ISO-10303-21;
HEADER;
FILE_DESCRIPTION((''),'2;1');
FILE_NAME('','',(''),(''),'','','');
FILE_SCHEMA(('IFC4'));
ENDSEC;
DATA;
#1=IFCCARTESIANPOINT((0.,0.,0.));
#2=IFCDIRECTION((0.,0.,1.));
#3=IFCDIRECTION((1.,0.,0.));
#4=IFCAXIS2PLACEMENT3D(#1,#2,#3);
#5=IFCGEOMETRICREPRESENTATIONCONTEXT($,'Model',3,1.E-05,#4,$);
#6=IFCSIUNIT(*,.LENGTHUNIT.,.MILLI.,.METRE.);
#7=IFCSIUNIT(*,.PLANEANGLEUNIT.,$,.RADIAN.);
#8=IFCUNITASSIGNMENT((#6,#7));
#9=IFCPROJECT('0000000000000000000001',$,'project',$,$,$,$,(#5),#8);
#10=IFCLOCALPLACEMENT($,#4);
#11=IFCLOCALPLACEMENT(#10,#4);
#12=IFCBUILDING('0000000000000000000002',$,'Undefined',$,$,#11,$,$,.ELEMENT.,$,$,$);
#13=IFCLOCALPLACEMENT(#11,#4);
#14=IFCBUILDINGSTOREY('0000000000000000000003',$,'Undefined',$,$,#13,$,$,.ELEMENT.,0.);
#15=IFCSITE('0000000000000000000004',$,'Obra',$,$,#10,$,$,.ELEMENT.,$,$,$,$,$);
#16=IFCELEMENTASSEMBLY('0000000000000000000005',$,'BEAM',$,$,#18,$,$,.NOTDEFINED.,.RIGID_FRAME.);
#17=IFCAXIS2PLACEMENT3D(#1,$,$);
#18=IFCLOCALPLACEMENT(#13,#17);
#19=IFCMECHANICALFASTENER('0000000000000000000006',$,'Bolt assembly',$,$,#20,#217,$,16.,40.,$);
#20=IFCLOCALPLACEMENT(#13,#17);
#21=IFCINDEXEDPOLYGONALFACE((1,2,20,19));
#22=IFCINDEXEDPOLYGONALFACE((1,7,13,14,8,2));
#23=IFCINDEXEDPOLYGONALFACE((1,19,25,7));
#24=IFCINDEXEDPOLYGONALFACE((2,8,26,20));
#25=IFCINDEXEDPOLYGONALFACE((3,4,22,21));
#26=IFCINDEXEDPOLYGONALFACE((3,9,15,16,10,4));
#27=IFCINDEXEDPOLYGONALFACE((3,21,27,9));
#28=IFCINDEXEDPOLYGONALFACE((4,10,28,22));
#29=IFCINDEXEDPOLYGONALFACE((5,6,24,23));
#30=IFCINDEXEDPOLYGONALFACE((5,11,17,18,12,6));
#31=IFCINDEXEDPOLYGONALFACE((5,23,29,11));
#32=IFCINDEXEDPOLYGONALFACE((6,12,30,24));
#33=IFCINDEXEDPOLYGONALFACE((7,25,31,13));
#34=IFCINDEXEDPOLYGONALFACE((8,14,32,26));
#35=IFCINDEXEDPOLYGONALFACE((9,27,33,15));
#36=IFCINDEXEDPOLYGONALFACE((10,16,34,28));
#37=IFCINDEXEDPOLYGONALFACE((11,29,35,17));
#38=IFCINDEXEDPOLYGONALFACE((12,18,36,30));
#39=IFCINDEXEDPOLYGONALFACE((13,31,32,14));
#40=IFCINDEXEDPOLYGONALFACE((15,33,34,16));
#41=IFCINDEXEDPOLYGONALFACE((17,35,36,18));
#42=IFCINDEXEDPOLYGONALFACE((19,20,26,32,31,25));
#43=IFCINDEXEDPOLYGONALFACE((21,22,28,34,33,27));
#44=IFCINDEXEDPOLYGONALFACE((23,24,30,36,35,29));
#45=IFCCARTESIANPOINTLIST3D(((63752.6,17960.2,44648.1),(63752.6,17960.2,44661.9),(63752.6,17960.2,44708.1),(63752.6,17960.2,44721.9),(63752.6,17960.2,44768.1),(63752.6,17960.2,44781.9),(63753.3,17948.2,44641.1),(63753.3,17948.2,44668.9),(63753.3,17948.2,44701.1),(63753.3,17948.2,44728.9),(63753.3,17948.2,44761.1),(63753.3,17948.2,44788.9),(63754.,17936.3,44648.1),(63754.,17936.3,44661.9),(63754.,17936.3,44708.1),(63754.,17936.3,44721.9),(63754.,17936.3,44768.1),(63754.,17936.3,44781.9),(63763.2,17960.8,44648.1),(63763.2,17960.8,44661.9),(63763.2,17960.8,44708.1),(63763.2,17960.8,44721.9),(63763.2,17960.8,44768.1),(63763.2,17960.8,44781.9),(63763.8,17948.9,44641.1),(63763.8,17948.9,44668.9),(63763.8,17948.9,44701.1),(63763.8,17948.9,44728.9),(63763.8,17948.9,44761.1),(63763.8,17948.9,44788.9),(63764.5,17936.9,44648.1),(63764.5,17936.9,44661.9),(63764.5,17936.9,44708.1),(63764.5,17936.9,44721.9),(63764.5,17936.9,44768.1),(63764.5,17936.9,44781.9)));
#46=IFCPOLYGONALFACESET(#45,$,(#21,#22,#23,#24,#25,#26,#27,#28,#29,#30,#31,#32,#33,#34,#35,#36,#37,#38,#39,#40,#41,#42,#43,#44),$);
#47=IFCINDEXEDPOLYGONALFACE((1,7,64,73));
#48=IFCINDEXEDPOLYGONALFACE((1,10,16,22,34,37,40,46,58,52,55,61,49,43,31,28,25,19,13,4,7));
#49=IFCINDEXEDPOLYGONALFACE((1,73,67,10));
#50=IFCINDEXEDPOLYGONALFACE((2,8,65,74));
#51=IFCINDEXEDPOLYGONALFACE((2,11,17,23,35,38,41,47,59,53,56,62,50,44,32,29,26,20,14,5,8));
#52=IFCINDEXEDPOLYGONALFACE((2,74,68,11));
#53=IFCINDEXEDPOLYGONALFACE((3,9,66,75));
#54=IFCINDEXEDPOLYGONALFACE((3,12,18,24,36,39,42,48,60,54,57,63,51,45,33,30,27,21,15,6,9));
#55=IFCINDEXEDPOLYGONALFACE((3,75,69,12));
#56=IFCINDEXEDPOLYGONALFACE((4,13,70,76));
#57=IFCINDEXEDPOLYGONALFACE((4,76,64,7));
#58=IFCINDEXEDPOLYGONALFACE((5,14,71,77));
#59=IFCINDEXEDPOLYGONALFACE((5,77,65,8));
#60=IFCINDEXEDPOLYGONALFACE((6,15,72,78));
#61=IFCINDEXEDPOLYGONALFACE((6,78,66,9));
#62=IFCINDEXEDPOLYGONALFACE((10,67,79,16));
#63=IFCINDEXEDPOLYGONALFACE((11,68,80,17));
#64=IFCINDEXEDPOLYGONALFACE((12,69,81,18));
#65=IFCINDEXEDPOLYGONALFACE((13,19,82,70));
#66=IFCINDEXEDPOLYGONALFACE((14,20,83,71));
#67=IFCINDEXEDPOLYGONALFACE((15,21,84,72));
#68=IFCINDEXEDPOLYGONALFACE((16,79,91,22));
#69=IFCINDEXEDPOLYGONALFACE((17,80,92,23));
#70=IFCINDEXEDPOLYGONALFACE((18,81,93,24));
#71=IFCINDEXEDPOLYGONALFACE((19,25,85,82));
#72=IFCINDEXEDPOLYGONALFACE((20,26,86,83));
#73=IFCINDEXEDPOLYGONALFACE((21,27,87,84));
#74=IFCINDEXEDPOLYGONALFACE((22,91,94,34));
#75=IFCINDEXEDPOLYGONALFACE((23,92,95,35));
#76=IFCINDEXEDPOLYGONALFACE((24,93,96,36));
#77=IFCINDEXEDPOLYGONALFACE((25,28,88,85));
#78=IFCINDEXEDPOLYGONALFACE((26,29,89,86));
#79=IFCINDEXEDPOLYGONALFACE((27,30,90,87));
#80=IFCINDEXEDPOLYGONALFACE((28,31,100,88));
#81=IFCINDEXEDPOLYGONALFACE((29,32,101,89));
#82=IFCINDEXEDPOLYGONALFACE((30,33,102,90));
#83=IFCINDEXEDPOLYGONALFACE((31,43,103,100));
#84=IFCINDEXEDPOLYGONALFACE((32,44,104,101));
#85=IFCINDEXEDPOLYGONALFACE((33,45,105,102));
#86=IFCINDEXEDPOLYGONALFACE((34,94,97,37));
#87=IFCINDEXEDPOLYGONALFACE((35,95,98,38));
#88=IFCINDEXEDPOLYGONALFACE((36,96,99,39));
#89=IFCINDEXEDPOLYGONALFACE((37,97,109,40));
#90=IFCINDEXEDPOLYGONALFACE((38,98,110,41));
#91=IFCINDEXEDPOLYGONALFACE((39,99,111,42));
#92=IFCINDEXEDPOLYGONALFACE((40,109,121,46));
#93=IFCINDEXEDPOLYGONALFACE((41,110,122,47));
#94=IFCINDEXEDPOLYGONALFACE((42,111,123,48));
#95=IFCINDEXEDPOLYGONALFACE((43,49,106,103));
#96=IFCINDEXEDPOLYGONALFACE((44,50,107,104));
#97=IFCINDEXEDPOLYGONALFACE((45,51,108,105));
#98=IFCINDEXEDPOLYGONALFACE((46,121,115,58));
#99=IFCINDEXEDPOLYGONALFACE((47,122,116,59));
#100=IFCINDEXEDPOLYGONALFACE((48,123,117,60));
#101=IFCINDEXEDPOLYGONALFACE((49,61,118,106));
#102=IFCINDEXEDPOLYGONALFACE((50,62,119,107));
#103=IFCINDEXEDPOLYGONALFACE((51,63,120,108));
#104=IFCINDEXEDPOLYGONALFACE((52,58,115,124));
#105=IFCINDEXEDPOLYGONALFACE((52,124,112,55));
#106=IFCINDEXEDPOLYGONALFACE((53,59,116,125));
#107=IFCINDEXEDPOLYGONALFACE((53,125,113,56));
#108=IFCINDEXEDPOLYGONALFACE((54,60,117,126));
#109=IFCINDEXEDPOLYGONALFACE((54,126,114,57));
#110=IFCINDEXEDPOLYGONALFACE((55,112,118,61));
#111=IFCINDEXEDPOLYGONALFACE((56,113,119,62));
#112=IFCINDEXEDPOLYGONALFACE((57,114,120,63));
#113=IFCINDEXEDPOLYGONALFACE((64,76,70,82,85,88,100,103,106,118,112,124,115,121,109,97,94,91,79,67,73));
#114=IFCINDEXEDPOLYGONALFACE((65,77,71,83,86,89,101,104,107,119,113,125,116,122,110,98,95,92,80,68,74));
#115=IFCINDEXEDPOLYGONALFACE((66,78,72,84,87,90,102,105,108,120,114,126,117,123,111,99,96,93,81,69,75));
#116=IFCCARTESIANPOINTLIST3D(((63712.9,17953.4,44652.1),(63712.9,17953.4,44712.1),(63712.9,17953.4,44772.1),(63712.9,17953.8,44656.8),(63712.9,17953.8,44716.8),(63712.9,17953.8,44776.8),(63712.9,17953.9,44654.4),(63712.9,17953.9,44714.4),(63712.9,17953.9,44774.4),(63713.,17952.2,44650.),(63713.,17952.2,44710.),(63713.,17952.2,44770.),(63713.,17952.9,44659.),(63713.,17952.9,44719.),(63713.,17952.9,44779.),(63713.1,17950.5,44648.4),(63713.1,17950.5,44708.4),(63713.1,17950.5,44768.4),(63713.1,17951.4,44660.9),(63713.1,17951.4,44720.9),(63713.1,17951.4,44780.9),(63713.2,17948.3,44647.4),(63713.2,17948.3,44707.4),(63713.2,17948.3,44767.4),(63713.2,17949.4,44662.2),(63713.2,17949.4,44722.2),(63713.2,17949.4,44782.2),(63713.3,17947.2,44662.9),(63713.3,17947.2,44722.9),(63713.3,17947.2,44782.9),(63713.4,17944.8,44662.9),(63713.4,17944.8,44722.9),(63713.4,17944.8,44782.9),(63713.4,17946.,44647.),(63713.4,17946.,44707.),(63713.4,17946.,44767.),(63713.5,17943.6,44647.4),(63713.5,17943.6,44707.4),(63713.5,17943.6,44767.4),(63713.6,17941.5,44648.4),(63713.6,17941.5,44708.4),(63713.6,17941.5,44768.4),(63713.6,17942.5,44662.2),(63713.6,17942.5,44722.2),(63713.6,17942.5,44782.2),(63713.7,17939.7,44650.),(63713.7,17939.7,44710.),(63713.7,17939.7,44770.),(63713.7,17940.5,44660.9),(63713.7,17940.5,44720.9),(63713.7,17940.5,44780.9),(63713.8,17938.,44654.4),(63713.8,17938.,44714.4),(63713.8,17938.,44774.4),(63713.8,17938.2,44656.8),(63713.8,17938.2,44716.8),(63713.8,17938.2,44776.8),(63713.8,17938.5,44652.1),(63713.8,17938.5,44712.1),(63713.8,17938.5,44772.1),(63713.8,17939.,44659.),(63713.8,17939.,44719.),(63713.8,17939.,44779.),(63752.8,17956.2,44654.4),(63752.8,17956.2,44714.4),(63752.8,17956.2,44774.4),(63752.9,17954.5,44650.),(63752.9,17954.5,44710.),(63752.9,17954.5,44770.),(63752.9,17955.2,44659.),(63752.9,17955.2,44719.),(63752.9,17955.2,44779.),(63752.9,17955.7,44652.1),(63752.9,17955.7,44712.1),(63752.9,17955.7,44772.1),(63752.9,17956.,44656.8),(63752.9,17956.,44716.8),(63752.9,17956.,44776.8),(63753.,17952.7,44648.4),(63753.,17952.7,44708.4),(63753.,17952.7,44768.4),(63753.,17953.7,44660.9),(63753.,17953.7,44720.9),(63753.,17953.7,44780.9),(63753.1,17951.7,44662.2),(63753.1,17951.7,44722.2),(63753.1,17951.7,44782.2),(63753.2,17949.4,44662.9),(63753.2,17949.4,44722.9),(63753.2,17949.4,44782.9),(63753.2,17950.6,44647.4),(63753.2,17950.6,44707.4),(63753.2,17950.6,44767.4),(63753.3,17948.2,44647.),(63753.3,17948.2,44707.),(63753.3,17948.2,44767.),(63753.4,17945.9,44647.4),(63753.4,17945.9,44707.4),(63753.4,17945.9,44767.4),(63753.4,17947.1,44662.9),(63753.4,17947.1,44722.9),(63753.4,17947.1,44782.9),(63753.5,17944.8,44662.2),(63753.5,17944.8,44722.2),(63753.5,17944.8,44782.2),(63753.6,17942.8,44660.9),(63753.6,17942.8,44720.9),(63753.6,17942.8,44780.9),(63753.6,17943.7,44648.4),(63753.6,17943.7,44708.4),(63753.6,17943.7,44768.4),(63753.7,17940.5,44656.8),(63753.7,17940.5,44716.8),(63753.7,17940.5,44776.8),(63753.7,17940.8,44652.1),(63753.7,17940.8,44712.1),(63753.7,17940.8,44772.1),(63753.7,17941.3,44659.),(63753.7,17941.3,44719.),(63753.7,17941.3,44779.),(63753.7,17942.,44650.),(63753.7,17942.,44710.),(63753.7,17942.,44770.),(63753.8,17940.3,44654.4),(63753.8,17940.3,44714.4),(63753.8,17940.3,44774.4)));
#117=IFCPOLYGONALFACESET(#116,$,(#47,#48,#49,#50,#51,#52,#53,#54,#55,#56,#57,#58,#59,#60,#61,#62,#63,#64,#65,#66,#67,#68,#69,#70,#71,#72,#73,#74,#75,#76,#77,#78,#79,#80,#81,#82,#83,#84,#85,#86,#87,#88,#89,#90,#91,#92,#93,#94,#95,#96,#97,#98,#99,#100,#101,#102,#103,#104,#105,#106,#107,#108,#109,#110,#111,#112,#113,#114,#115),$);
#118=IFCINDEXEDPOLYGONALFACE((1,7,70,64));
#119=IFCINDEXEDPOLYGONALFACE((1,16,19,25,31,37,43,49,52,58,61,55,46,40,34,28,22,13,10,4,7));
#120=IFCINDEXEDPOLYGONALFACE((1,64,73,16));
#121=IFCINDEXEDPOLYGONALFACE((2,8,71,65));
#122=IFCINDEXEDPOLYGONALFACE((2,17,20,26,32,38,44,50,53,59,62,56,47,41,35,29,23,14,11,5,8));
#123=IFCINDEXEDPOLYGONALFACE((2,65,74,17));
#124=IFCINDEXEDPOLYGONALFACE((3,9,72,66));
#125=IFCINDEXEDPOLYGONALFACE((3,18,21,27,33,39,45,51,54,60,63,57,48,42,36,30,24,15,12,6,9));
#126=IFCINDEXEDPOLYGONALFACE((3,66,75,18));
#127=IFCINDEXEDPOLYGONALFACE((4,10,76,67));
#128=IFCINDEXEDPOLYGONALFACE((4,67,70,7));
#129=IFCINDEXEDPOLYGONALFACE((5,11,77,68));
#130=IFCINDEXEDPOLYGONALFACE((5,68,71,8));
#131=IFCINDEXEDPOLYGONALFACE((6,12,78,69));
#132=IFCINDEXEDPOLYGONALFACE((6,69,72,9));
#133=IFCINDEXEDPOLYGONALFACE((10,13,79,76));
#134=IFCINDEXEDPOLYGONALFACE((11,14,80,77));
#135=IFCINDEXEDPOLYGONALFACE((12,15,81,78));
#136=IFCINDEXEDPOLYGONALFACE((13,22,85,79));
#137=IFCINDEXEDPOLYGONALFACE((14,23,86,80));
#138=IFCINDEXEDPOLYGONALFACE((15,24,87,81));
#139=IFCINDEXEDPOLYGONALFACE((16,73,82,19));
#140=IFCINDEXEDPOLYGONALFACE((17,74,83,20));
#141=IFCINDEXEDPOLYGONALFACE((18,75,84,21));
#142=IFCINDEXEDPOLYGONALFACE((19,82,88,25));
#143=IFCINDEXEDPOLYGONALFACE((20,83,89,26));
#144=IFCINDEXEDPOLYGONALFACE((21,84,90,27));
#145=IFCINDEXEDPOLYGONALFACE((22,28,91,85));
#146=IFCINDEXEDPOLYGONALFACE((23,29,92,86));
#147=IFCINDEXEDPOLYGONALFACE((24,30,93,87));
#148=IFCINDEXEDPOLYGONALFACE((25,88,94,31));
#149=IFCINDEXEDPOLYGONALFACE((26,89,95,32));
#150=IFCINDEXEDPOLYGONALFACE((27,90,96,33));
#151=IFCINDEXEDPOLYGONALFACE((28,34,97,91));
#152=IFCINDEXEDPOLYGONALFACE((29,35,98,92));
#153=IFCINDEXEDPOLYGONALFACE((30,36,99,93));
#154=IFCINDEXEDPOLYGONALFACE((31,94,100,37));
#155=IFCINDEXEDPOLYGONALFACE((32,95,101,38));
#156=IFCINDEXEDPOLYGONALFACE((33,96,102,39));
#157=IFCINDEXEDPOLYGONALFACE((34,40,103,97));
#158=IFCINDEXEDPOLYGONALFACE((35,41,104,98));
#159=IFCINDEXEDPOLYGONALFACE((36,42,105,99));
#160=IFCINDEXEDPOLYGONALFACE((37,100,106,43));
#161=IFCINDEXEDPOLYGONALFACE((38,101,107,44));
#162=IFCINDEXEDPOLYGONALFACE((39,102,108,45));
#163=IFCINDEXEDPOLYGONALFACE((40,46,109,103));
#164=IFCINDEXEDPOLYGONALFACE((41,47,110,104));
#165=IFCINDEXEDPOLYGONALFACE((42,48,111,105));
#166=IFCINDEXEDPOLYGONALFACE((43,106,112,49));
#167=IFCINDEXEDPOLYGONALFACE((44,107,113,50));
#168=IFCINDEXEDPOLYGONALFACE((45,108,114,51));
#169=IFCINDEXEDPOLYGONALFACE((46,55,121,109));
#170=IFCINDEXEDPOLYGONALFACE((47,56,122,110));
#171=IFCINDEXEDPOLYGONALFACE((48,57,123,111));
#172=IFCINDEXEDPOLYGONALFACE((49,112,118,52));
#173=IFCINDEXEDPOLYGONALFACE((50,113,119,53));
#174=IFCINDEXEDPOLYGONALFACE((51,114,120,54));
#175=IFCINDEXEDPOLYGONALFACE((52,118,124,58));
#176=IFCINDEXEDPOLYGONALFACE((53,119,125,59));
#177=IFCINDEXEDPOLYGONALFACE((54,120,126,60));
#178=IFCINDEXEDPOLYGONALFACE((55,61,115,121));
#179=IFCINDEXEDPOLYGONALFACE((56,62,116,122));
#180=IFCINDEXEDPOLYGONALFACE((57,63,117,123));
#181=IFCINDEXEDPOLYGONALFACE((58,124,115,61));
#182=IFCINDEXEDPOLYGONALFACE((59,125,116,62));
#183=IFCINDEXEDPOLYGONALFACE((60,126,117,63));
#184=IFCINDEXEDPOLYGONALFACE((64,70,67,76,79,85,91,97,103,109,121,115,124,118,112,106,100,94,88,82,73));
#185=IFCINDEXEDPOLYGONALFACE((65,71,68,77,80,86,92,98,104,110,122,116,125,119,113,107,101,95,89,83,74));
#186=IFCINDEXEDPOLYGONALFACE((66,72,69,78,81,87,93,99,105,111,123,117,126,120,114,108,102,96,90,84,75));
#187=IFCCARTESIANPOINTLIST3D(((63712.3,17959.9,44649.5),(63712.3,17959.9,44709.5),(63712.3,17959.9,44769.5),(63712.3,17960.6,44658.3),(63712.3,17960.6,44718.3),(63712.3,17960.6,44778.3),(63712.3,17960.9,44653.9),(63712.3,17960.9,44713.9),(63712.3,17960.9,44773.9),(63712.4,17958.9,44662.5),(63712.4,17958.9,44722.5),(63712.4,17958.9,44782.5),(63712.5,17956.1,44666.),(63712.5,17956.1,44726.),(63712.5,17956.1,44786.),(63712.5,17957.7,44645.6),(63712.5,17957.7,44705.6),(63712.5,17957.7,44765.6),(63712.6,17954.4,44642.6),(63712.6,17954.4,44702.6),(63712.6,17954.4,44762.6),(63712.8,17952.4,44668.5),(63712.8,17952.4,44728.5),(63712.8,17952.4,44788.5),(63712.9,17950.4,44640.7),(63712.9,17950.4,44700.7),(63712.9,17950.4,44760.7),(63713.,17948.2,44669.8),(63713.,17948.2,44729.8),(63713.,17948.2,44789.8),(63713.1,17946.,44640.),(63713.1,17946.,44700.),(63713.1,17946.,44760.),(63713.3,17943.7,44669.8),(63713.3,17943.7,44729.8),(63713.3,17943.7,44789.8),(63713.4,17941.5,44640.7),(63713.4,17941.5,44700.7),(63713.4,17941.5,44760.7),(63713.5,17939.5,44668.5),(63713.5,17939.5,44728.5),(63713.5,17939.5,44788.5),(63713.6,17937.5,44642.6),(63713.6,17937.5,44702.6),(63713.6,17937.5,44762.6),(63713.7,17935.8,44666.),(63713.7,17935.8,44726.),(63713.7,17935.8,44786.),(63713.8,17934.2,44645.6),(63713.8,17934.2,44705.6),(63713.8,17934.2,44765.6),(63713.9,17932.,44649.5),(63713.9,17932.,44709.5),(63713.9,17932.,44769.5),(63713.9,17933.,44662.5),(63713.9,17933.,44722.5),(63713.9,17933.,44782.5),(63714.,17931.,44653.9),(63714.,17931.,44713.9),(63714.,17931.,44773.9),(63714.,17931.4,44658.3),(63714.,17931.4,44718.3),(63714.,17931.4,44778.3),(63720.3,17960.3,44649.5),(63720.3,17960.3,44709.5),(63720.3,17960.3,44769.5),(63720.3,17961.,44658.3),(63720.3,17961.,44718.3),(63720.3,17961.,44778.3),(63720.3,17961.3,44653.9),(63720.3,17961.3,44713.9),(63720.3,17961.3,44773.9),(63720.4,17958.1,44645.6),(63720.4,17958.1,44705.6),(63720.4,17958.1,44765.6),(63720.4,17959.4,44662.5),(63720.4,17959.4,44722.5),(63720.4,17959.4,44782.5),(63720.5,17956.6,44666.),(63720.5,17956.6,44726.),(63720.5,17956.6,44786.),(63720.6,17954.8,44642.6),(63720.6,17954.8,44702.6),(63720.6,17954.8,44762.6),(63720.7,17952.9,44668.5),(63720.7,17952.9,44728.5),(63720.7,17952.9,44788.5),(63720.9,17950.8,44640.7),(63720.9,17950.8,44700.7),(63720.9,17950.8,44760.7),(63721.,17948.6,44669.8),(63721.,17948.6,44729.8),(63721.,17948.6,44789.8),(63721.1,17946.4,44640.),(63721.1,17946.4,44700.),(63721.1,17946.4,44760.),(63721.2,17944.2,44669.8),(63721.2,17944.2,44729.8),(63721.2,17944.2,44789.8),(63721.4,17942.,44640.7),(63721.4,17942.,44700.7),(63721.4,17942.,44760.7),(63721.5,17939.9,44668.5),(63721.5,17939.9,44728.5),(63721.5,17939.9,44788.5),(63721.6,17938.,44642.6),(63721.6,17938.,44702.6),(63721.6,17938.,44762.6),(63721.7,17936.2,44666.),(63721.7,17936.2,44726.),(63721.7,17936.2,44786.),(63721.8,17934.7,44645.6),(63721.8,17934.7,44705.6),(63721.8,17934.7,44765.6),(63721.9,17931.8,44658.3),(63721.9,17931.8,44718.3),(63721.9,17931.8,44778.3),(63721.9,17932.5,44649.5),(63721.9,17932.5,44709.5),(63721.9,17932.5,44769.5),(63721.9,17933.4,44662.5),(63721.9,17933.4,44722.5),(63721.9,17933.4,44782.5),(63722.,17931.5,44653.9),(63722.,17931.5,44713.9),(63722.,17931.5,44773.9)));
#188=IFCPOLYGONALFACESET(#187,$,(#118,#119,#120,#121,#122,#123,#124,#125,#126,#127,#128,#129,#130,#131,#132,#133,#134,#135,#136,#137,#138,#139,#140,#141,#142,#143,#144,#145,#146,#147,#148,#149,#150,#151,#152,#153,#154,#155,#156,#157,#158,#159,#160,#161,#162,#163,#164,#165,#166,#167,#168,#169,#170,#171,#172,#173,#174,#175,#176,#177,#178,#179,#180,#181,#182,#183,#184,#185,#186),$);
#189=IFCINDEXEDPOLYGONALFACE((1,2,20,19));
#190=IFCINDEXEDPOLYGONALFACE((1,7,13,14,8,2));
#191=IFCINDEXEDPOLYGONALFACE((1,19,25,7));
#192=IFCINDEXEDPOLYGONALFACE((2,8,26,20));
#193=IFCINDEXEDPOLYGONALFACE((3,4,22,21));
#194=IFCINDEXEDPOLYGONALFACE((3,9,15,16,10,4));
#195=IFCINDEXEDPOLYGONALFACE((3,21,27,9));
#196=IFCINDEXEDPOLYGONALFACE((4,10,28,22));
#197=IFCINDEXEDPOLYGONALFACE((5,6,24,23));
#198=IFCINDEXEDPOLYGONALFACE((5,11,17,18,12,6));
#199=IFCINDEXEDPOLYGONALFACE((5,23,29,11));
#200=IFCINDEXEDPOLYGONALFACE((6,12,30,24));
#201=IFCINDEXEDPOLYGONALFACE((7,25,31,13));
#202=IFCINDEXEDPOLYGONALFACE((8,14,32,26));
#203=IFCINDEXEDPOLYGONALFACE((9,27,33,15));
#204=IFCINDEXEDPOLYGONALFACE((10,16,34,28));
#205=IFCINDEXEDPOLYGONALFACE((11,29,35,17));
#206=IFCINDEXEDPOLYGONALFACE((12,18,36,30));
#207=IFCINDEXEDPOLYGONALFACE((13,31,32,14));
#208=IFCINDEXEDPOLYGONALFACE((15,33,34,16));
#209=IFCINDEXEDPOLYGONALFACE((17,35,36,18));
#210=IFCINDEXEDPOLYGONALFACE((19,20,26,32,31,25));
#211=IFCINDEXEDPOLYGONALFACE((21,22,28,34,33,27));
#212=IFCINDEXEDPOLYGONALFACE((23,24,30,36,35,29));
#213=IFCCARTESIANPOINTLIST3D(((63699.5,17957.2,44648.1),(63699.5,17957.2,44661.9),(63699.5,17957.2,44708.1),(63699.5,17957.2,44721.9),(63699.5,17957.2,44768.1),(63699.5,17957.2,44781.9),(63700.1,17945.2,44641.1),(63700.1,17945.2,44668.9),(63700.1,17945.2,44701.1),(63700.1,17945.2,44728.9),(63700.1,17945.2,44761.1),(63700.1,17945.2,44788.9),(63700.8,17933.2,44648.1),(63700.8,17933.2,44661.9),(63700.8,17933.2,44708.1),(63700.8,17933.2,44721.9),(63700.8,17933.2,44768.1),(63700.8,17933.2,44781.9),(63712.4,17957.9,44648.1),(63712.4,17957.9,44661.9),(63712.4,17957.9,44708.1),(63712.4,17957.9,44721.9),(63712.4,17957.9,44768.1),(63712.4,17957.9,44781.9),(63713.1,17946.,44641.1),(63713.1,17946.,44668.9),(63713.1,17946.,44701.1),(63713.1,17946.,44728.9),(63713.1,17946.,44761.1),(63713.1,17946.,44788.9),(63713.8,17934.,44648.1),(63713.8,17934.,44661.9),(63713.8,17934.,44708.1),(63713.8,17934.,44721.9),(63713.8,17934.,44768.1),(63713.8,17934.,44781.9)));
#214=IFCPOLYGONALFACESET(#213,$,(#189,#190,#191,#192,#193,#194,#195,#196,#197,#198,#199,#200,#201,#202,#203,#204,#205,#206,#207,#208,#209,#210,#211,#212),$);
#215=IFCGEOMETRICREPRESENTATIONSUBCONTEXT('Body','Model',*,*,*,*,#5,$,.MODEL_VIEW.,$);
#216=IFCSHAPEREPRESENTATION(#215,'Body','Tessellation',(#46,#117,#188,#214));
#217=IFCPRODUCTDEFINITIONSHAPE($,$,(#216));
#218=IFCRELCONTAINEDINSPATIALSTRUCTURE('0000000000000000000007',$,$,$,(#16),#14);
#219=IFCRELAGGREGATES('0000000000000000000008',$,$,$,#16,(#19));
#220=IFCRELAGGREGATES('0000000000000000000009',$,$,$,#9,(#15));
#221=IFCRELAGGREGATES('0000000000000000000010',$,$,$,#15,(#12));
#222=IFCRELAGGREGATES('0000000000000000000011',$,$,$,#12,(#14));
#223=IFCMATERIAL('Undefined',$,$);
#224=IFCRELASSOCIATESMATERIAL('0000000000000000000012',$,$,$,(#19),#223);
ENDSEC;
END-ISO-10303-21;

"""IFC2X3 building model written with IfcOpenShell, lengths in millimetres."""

from ifc_helpers import new_model, si_unit, frame, origin_with_axes, origin_2d_with_axis, place, context, subcontext, project, spatial, polyline, circle, outline, extrude, source, transform, mapped, material, element, aggregate, save


model = new_model("IFC2X3")

# Units and contexts
model_context = context("Model", 3, precision=1e-05, world=origin_with_axes())
body_context = subcontext(model_context, "Body", "Model", "MODEL_VIEW")
ifc_project = project(units=[si_unit("LENGTHUNIT", "METRE", prefix="MILLI"), si_unit("PLANEANGLEUNIT", "RADIAN")], contexts=[model_context])

# Site, building, storey
site_placement = place(None, origin_with_axes())
site = spatial("IfcSite", under=ifc_project, at=site_placement, Name="Obra", CompositionType="ELEMENT")
building_placement = place(site_placement, origin_with_axes())
building = spatial("IfcBuilding", under=site, at=building_placement, Name="Undefined", CompositionType="ELEMENT")
storey_placement = place(building_placement, origin_with_axes())
storey = spatial("IfcBuildingStorey", under=building, at=storey_placement, Name="Undefined", CompositionType="ELEMENT", Elevation=0.0)

# Element assembly
assembly_1_placement = place(storey_placement, origin_with_axes())
assembly_1 = element("IfcElementAssembly", 1, at=assembly_1_placement, inside=storey, Name="BEAM", AssemblyPlace="NOTDEFINED", PredefinedType="RIGID_FRAME")

# Mechanical fastener
ifc_material_1 = material(Name="Undefined")
shared_shape_1 = source(origin_with_axes(), body_context, "Body", "SweptSolid", [
    extrude(outline(polyline([(13.9, 0.0), (6.9, 12.0), (-6.9, 12.0), (-13.9, 0.0), (-6.9, -12.0), (6.9, -12.0), (13.9, 0.0)])), frame((0.0, -45.9, 0.0), z_axis=(0.0, 1.0, 0.0), x_axis=(1.0, 0.0, 0.0)), (0.0, 0.0, 1.0), 10.6),
    extrude(circle(Radius=8.0, at=origin_2d_with_axis()), frame((0.0, -35.3, 0.0), z_axis=(0.0, 1.0, 0.0), x_axis=(1.0, 0.0, 0.0)), (0.0, 0.0, 1.0), 40.0),
    extrude(circle(Radius=15.0, at=origin_2d_with_axis()), frame((0.0, -3.1, 0.0), z_axis=(0.0, 1.0, 0.0), x_axis=(1.0, 0.0, 0.0)), (0.0, 0.0, 1.0), 8.0),
    extrude(outline(polyline([(13.9, 0.0), (6.9, 12.0), (-6.9, 12.0), (-13.9, 0.0), (-6.9, -12.0), (6.9, -12.0), (13.9, 0.0)])), frame((0.0, 4.9, 0.0), z_axis=(0.0, 1.0, 0.0), x_axis=(1.0, 0.0, 0.0)), (0.0, 0.0, 1.0), 13.0),
])
mechanical_fastener_1_placement = place(assembly_1_placement, frame((63720.9, 17896.3, 44835.0), z_axis=(-0.057107, 0.998368, 0.0), x_axis=(0.0, 0.0, -1.0)))
mechanical_fastener_1 = element("IfcMechanicalFastener", 2, at=mechanical_fastener_1_placement, material=ifc_material_1, Name="Bolt assembly", NominalDiameter=16.0, NominalLength=40.0, context=body_context, shape_type="MappedRepresentation", body=[
    mapped(shared_shape_1, transform((60.0, 0.0, 50.0))),
    mapped(shared_shape_1, transform((120.0, 0.0, 50.0))),
    mapped(shared_shape_1, transform((180.0, 0.0, 50.0))),
])
aggregate(assembly_1, [mechanical_fastener_1])

save(model, "model.ifc")
